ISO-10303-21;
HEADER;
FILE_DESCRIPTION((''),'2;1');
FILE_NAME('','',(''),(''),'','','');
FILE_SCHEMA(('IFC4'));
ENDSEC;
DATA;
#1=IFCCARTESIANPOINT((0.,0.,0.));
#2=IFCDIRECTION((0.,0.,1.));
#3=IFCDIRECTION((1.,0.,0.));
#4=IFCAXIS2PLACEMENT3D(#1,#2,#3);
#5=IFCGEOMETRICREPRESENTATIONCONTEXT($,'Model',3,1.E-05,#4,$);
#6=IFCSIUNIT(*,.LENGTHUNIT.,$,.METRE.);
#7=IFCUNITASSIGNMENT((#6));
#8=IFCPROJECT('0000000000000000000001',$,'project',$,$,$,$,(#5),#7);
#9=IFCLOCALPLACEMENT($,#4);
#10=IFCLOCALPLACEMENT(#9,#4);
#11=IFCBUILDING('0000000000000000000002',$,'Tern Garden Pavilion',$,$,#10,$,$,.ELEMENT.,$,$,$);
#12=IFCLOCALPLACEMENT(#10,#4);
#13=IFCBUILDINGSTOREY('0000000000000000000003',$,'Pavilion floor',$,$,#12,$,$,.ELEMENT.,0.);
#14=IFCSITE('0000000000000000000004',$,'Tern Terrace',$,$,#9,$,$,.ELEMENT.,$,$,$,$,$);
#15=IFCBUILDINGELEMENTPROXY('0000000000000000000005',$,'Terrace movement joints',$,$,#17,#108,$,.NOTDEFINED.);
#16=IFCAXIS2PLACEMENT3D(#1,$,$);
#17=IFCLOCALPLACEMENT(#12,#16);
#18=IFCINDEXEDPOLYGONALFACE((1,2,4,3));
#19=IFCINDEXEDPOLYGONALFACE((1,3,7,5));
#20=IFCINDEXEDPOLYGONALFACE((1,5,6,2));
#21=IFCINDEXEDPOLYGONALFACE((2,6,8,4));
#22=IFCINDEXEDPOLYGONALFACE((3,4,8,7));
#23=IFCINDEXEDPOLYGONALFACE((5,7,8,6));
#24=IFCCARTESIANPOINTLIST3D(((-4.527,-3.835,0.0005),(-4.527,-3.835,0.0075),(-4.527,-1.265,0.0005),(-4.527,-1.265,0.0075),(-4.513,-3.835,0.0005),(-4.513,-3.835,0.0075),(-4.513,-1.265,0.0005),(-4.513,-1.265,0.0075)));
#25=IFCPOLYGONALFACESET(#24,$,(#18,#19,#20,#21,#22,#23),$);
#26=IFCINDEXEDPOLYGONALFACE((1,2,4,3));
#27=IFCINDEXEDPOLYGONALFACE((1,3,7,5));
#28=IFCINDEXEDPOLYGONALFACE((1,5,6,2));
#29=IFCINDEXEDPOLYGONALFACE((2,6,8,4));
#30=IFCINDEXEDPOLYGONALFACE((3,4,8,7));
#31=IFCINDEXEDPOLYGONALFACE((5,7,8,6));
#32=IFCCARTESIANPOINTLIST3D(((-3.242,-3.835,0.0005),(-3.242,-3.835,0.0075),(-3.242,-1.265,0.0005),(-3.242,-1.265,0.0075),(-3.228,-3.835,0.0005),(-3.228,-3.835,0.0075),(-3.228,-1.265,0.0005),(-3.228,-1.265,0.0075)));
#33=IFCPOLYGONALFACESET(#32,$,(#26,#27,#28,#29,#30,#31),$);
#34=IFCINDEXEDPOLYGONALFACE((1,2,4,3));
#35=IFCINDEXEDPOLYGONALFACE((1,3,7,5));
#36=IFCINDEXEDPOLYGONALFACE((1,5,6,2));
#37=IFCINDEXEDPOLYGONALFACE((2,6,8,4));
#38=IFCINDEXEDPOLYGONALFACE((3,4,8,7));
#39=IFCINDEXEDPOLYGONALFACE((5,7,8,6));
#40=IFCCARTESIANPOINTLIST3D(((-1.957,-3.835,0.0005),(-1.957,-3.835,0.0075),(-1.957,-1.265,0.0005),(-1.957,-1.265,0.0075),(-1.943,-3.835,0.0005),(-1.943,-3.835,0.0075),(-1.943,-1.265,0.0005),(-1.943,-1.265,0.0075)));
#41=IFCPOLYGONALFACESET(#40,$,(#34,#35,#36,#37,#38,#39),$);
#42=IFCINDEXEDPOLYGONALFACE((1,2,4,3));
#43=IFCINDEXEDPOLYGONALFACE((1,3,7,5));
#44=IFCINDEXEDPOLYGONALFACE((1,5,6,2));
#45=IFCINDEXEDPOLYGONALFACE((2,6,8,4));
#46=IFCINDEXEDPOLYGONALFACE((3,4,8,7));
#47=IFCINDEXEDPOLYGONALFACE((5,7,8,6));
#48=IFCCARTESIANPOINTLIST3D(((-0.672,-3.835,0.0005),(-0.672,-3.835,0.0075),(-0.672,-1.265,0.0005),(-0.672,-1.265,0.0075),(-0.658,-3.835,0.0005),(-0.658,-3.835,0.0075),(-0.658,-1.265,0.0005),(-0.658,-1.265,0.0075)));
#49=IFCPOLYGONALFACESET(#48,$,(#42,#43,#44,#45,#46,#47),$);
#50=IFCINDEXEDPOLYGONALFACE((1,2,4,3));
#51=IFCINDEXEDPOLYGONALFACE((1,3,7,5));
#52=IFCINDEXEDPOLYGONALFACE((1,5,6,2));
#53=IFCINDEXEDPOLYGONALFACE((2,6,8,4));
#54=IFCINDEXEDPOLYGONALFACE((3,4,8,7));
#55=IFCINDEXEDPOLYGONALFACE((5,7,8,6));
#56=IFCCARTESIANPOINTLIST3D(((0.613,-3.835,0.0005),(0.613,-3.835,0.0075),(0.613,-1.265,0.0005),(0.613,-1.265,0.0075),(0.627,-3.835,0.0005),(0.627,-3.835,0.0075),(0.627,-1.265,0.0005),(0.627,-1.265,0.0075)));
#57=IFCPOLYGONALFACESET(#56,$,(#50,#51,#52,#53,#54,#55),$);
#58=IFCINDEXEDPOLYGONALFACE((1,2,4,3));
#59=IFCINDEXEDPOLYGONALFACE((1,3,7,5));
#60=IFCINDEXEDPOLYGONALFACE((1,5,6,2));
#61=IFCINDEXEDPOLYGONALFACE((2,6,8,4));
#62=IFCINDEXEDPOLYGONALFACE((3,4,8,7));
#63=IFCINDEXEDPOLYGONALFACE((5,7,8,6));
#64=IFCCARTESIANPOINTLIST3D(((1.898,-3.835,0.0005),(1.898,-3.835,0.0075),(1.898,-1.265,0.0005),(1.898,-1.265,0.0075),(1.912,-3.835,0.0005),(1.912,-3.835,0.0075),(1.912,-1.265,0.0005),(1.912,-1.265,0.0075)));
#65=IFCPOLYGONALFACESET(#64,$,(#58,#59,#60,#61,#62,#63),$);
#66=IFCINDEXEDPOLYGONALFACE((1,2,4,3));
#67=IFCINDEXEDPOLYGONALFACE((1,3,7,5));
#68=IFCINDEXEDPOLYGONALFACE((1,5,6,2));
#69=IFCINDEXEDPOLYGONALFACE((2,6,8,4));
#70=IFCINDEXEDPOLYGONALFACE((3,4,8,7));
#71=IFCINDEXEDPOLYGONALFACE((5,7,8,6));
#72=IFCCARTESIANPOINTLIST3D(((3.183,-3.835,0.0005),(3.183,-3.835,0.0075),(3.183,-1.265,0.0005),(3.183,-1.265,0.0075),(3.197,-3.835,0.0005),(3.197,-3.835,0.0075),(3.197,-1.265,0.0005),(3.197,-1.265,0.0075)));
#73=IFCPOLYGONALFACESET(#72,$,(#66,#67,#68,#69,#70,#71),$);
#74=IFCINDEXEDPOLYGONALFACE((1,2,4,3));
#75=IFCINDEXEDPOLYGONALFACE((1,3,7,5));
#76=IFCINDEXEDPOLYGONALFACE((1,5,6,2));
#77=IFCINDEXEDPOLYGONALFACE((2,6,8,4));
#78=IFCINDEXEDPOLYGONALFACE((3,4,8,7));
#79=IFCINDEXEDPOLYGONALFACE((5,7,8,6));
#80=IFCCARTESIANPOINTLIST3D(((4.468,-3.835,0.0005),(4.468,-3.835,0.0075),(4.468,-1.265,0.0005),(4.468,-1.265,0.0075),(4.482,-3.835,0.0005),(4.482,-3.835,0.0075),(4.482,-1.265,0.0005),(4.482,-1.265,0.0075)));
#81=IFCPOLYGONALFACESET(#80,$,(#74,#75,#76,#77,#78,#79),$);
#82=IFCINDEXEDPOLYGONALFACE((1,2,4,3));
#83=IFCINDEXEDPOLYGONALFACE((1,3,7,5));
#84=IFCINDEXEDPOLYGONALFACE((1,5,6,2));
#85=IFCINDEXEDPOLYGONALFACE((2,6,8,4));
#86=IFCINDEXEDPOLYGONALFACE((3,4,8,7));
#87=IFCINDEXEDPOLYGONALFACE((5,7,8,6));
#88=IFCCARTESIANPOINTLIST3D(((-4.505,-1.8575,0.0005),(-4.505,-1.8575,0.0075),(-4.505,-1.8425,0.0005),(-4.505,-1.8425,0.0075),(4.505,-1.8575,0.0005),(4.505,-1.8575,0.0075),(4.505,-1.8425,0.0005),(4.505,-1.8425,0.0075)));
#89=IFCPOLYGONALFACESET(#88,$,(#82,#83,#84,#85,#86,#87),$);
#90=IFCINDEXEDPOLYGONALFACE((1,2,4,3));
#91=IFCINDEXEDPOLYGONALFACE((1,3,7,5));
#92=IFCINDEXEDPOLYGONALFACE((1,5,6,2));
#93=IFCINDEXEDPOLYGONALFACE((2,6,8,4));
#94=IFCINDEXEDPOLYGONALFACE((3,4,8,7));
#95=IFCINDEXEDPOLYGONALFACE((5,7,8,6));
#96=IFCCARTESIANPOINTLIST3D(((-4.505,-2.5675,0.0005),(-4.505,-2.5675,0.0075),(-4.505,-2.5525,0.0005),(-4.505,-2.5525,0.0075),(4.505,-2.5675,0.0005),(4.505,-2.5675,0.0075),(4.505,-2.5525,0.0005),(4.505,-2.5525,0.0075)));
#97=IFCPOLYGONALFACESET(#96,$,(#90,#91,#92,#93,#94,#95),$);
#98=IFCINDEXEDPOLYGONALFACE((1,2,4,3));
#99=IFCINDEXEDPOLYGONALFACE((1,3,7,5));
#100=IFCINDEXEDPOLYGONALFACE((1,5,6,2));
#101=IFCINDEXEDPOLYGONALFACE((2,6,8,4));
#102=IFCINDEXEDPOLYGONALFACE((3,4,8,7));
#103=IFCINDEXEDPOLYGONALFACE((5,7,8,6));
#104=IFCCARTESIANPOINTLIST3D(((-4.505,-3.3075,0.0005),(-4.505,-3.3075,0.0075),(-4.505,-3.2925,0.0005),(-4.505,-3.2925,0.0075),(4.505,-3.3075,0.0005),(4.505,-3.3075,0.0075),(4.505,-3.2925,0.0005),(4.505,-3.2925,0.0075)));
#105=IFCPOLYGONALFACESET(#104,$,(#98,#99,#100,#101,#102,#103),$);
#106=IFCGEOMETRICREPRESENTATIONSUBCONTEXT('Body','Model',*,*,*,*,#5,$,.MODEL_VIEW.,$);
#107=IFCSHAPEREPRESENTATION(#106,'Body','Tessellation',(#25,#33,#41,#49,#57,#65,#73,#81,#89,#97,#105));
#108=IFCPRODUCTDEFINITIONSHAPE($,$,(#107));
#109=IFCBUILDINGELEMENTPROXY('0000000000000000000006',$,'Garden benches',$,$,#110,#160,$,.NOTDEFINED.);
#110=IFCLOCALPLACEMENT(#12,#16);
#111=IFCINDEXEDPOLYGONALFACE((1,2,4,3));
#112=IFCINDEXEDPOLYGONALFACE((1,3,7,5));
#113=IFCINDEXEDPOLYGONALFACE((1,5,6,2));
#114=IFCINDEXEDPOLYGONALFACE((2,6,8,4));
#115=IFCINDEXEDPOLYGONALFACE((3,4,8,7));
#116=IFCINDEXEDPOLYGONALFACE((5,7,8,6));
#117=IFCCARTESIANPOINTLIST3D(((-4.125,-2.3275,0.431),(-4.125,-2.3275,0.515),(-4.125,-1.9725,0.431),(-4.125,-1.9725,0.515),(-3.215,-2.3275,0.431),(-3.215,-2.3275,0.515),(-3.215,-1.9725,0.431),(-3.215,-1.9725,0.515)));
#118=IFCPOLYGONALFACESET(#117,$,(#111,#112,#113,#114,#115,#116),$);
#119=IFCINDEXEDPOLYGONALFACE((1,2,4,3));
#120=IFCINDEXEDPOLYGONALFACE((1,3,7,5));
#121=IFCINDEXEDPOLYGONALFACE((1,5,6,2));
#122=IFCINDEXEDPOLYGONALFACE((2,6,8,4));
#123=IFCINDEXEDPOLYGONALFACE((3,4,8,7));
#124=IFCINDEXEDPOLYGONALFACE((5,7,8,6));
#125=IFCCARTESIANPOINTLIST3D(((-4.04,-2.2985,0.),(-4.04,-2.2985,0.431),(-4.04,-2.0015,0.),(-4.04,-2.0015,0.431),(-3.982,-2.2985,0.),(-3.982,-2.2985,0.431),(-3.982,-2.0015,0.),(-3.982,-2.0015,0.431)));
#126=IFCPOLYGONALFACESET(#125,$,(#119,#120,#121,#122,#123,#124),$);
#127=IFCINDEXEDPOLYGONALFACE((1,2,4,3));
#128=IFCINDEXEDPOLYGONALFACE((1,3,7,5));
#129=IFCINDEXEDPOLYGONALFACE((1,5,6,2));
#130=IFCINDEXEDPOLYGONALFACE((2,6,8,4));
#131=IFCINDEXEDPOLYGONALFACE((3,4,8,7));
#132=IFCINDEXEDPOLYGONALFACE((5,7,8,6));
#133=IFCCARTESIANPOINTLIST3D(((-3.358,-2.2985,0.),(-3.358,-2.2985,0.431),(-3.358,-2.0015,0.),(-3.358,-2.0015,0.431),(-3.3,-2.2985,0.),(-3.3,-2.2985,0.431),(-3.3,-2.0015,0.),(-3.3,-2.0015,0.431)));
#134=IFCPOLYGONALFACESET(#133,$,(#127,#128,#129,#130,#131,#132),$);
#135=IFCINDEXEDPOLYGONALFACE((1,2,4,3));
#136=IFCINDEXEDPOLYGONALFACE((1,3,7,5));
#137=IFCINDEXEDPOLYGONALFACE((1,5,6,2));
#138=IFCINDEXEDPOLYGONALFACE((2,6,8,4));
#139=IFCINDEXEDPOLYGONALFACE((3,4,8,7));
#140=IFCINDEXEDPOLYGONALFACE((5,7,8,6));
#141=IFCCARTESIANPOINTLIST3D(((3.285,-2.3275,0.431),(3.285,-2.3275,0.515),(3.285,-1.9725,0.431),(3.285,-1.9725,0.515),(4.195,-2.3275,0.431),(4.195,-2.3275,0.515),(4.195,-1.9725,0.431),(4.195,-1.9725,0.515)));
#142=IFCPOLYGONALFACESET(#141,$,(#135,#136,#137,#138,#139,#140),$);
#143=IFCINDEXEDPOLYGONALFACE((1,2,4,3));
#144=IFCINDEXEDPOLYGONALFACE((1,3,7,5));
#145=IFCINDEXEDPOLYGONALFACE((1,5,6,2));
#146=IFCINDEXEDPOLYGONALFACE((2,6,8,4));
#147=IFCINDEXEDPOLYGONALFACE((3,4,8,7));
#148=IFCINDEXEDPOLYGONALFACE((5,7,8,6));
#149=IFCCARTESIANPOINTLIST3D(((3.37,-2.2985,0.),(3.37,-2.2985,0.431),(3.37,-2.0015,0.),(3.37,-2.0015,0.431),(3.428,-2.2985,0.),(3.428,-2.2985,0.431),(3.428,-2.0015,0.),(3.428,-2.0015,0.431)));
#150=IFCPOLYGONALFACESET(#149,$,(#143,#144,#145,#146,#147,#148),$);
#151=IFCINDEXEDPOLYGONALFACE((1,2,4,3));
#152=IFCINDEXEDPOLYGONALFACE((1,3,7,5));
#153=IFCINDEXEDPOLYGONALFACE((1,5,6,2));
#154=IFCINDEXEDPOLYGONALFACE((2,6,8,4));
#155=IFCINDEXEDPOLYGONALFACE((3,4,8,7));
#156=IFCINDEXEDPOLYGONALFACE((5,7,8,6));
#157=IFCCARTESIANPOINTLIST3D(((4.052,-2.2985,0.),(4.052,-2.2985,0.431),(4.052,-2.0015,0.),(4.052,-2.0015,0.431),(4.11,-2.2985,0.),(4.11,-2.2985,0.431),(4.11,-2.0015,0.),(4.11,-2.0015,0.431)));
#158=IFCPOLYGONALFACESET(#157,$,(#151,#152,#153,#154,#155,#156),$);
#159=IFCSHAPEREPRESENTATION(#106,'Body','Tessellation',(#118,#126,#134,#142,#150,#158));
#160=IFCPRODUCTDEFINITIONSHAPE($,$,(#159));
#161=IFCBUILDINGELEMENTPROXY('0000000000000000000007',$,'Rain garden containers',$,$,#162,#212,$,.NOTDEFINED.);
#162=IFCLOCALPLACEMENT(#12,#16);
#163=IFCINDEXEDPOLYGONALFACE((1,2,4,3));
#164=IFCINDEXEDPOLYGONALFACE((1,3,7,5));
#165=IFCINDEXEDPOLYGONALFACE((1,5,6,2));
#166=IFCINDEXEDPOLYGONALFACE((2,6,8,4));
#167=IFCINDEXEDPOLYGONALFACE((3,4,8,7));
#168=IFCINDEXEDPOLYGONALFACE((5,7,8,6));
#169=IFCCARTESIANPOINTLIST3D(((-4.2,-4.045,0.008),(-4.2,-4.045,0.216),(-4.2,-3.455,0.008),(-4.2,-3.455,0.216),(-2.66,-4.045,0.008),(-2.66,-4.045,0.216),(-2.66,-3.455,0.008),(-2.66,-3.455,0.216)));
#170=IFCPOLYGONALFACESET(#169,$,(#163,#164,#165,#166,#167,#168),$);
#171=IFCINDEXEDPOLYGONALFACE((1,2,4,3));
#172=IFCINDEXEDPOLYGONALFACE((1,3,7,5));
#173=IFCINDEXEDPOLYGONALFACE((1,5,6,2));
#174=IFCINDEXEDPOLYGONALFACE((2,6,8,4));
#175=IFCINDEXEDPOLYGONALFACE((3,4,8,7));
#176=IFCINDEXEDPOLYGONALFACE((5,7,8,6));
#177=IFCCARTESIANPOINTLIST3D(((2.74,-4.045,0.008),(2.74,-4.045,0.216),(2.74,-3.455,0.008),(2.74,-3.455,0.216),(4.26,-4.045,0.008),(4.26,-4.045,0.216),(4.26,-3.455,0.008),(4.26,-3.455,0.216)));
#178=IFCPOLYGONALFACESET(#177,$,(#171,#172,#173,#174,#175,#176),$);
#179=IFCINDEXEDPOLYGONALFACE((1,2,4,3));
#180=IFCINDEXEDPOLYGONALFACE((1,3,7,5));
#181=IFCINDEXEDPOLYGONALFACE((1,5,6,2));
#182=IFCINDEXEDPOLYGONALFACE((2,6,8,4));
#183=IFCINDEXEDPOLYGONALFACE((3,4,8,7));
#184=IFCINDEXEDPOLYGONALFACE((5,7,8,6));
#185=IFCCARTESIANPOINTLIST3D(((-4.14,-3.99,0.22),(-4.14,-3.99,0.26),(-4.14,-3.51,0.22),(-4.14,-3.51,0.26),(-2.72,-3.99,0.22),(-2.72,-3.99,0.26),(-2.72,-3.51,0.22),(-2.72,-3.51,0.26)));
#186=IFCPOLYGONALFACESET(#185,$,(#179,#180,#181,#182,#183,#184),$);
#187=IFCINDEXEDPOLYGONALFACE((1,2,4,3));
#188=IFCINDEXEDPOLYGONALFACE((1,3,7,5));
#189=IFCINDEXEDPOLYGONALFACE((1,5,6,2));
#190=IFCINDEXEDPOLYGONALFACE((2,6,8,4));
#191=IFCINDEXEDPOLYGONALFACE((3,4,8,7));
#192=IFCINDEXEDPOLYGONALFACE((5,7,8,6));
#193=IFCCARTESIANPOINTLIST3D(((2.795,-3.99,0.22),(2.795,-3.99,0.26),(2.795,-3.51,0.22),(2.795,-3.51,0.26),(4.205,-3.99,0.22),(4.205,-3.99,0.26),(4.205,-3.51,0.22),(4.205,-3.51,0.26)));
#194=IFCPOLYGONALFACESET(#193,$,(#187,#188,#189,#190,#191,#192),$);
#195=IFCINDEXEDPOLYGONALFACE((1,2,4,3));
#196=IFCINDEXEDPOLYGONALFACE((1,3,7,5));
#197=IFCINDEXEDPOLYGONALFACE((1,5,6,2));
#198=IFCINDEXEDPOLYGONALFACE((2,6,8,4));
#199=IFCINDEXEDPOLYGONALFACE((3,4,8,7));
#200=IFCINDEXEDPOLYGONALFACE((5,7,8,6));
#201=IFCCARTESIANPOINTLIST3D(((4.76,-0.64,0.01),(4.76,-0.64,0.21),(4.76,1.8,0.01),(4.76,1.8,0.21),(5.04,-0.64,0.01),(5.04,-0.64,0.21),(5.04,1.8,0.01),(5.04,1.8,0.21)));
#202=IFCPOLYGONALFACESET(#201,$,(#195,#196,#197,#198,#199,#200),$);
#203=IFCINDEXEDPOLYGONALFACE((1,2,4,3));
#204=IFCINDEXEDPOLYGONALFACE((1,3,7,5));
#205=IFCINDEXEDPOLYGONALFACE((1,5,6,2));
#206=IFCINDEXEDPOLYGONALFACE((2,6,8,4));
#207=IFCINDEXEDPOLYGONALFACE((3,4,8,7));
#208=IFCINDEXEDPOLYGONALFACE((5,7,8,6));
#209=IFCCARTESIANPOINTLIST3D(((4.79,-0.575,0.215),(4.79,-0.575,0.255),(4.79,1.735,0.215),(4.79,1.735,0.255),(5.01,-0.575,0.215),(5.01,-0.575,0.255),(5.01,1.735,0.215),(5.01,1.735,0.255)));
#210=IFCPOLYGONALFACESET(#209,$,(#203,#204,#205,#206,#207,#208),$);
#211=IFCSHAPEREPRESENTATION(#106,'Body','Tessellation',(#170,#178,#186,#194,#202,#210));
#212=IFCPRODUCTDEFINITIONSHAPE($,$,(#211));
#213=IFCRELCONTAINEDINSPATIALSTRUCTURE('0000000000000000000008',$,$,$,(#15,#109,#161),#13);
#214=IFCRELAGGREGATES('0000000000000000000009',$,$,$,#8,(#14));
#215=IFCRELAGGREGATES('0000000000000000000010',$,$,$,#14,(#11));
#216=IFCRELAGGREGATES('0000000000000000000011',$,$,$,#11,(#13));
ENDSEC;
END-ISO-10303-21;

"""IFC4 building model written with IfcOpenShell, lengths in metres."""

from ifc_helpers import new_model, si_unit, frame, origin_with_axes, origin_2d, place, context, subcontext, project, spatial, rectangle, extrude, element, save


model = new_model("IFC4")

# Units and contexts
model_context = context("Model", 3, precision=1e-05, world=origin_with_axes())
body_context = subcontext(model_context, "Body", "Model", "MODEL_VIEW")
ifc_project = project(units=[si_unit("LENGTHUNIT", "METRE")], contexts=[model_context])

# Site, building, storey
site_placement = place(None, origin_with_axes())
site = spatial("IfcSite", under=ifc_project, at=site_placement, Name="Tern Terrace", CompositionType="ELEMENT")
building_placement = place(site_placement, origin_with_axes())
building = spatial("IfcBuilding", under=site, at=building_placement, Name="Tern Garden Pavilion", CompositionType="ELEMENT")
storey_placement = place(building_placement, origin_with_axes())
storey = spatial("IfcBuildingStorey", under=building, at=storey_placement, Name="Pavilion floor", CompositionType="ELEMENT", Elevation=0.0)

# Building element proxies
proxy_1_placement = place(storey_placement, origin_with_axes())
element("IfcBuildingElementProxy", 1, at=proxy_1_placement, inside=storey, Name="Terrace movement joints", PredefinedType="NOTDEFINED", context=body_context, shape_type="SweptSolid", body=[
    extrude(rectangle(XDim=0.014, YDim=2.57, at=origin_2d()), frame((-4.52, -2.55, 0.0005), z_axis=(0.0, 0.0, 1.0), x_axis=(1.0, 0.0, 0.0)), (0.0, 0.0, 1.0), 0.007),
    extrude(rectangle(XDim=0.014, YDim=2.57, at=origin_2d()), frame((-3.235, -2.55, 0.0005), z_axis=(0.0, 0.0, 1.0), x_axis=(1.0, 0.0, 0.0)), (0.0, 0.0, 1.0), 0.007),
    extrude(rectangle(XDim=0.014, YDim=2.57, at=origin_2d()), frame((-1.95, -2.55, 0.0005), z_axis=(0.0, 0.0, 1.0), x_axis=(1.0, 0.0, 0.0)), (0.0, 0.0, 1.0), 0.007),
    extrude(rectangle(XDim=0.014, YDim=2.57, at=origin_2d()), frame((-0.665, -2.55, 0.0005), z_axis=(0.0, 0.0, 1.0), x_axis=(1.0, 0.0, 0.0)), (0.0, 0.0, 1.0), 0.007),
    extrude(rectangle(XDim=0.014, YDim=2.57, at=origin_2d()), frame((0.62, -2.55, 0.0005), z_axis=(0.0, 0.0, 1.0), x_axis=(1.0, 0.0, 0.0)), (0.0, 0.0, 1.0), 0.007),
    extrude(rectangle(XDim=0.014, YDim=2.57, at=origin_2d()), frame((1.905, -2.55, 0.0005), z_axis=(0.0, 0.0, 1.0), x_axis=(1.0, 0.0, 0.0)), (0.0, 0.0, 1.0), 0.007),
    extrude(rectangle(XDim=0.014, YDim=2.57, at=origin_2d()), frame((3.19, -2.55, 0.0005), z_axis=(0.0, 0.0, 1.0), x_axis=(1.0, 0.0, 0.0)), (0.0, 0.0, 1.0), 0.007),
    extrude(rectangle(XDim=0.014, YDim=2.57, at=origin_2d()), frame((4.475, -2.55, 0.0005), z_axis=(0.0, 0.0, 1.0), x_axis=(1.0, 0.0, 0.0)), (0.0, 0.0, 1.0), 0.007),
    extrude(rectangle(XDim=9.01, YDim=0.015, at=origin_2d()), frame((0.0, -1.85, 0.0005), z_axis=(0.0, 0.0, 1.0), x_axis=(1.0, 0.0, 0.0)), (0.0, 0.0, 1.0), 0.007),
    extrude(rectangle(XDim=9.01, YDim=0.015, at=origin_2d()), frame((0.0, -2.56, 0.0005), z_axis=(0.0, 0.0, 1.0), x_axis=(1.0, 0.0, 0.0)), (0.0, 0.0, 1.0), 0.007),
    extrude(rectangle(XDim=9.01, YDim=0.015, at=origin_2d()), frame((0.0, -3.3, 0.0005), z_axis=(0.0, 0.0, 1.0), x_axis=(1.0, 0.0, 0.0)), (0.0, 0.0, 1.0), 0.007),
])
proxy_2_placement = place(storey_placement, origin_with_axes())
element("IfcBuildingElementProxy", 2, at=proxy_2_placement, inside=storey, Name="Garden benches", PredefinedType="NOTDEFINED", context=body_context, shape_type="SweptSolid", body=[
    extrude(rectangle(XDim=0.91, YDim=0.355, at=origin_2d()), frame((-3.67, -2.15, 0.431), z_axis=(0.0, 0.0, 1.0), x_axis=(1.0, 0.0, 0.0)), (0.0, 0.0, 1.0), 0.084),
    extrude(rectangle(XDim=0.058, YDim=0.297, at=origin_2d()), frame((-4.011, -2.15, 0.0), z_axis=(0.0, 0.0, 1.0), x_axis=(1.0, 0.0, 0.0)), (0.0, 0.0, 1.0), 0.431),
    extrude(rectangle(XDim=0.058, YDim=0.297, at=origin_2d()), frame((-3.329, -2.15, 0.0), z_axis=(0.0, 0.0, 1.0), x_axis=(1.0, 0.0, 0.0)), (0.0, 0.0, 1.0), 0.431),
    extrude(rectangle(XDim=0.91, YDim=0.355, at=origin_2d()), frame((3.74, -2.15, 0.431), z_axis=(0.0, 0.0, 1.0), x_axis=(1.0, 0.0, 0.0)), (0.0, 0.0, 1.0), 0.084),
    extrude(rectangle(XDim=0.058, YDim=0.297, at=origin_2d()), frame((3.399, -2.15, 0.0), z_axis=(0.0, 0.0, 1.0), x_axis=(1.0, 0.0, 0.0)), (0.0, 0.0, 1.0), 0.431),
    extrude(rectangle(XDim=0.058, YDim=0.297, at=origin_2d()), frame((4.081, -2.15, 0.0), z_axis=(0.0, 0.0, 1.0), x_axis=(1.0, 0.0, 0.0)), (0.0, 0.0, 1.0), 0.431),
])
proxy_3_placement = place(storey_placement, origin_with_axes())
element("IfcBuildingElementProxy", 3, at=proxy_3_placement, inside=storey, Name="Rain garden containers", PredefinedType="NOTDEFINED", context=body_context, shape_type="SweptSolid", body=[
    extrude(rectangle(XDim=1.54, YDim=0.59, at=origin_2d()), frame((-3.43, -3.75, 0.008), z_axis=(0.0, 0.0, 1.0), x_axis=(1.0, 0.0, 0.0)), (0.0, 0.0, 1.0), 0.208),
    extrude(rectangle(XDim=1.52, YDim=0.59, at=origin_2d()), frame((3.5, -3.75, 0.008), z_axis=(0.0, 0.0, 1.0), x_axis=(1.0, 0.0, 0.0)), (0.0, 0.0, 1.0), 0.208),
    extrude(rectangle(XDim=1.42, YDim=0.48, at=origin_2d()), frame((-3.43, -3.75, 0.22), z_axis=(0.0, 0.0, 1.0), x_axis=(1.0, 0.0, 0.0)), (0.0, 0.0, 1.0), 0.04),
    extrude(rectangle(XDim=1.41, YDim=0.48, at=origin_2d()), frame((3.5, -3.75, 0.22), z_axis=(0.0, 0.0, 1.0), x_axis=(1.0, 0.0, 0.0)), (0.0, 0.0, 1.0), 0.04),
    extrude(rectangle(XDim=0.28, YDim=2.44, at=origin_2d()), frame((4.9, 0.58, 0.01), z_axis=(0.0, 0.0, 1.0), x_axis=(1.0, 0.0, 0.0)), (0.0, 0.0, 1.0), 0.2),
    extrude(rectangle(XDim=0.22, YDim=2.31, at=origin_2d()), frame((4.9, 0.58, 0.215), z_axis=(0.0, 0.0, 1.0), x_axis=(1.0, 0.0, 0.0)), (0.0, 0.0, 1.0), 0.04),
])

save(model, "model.ifc")
